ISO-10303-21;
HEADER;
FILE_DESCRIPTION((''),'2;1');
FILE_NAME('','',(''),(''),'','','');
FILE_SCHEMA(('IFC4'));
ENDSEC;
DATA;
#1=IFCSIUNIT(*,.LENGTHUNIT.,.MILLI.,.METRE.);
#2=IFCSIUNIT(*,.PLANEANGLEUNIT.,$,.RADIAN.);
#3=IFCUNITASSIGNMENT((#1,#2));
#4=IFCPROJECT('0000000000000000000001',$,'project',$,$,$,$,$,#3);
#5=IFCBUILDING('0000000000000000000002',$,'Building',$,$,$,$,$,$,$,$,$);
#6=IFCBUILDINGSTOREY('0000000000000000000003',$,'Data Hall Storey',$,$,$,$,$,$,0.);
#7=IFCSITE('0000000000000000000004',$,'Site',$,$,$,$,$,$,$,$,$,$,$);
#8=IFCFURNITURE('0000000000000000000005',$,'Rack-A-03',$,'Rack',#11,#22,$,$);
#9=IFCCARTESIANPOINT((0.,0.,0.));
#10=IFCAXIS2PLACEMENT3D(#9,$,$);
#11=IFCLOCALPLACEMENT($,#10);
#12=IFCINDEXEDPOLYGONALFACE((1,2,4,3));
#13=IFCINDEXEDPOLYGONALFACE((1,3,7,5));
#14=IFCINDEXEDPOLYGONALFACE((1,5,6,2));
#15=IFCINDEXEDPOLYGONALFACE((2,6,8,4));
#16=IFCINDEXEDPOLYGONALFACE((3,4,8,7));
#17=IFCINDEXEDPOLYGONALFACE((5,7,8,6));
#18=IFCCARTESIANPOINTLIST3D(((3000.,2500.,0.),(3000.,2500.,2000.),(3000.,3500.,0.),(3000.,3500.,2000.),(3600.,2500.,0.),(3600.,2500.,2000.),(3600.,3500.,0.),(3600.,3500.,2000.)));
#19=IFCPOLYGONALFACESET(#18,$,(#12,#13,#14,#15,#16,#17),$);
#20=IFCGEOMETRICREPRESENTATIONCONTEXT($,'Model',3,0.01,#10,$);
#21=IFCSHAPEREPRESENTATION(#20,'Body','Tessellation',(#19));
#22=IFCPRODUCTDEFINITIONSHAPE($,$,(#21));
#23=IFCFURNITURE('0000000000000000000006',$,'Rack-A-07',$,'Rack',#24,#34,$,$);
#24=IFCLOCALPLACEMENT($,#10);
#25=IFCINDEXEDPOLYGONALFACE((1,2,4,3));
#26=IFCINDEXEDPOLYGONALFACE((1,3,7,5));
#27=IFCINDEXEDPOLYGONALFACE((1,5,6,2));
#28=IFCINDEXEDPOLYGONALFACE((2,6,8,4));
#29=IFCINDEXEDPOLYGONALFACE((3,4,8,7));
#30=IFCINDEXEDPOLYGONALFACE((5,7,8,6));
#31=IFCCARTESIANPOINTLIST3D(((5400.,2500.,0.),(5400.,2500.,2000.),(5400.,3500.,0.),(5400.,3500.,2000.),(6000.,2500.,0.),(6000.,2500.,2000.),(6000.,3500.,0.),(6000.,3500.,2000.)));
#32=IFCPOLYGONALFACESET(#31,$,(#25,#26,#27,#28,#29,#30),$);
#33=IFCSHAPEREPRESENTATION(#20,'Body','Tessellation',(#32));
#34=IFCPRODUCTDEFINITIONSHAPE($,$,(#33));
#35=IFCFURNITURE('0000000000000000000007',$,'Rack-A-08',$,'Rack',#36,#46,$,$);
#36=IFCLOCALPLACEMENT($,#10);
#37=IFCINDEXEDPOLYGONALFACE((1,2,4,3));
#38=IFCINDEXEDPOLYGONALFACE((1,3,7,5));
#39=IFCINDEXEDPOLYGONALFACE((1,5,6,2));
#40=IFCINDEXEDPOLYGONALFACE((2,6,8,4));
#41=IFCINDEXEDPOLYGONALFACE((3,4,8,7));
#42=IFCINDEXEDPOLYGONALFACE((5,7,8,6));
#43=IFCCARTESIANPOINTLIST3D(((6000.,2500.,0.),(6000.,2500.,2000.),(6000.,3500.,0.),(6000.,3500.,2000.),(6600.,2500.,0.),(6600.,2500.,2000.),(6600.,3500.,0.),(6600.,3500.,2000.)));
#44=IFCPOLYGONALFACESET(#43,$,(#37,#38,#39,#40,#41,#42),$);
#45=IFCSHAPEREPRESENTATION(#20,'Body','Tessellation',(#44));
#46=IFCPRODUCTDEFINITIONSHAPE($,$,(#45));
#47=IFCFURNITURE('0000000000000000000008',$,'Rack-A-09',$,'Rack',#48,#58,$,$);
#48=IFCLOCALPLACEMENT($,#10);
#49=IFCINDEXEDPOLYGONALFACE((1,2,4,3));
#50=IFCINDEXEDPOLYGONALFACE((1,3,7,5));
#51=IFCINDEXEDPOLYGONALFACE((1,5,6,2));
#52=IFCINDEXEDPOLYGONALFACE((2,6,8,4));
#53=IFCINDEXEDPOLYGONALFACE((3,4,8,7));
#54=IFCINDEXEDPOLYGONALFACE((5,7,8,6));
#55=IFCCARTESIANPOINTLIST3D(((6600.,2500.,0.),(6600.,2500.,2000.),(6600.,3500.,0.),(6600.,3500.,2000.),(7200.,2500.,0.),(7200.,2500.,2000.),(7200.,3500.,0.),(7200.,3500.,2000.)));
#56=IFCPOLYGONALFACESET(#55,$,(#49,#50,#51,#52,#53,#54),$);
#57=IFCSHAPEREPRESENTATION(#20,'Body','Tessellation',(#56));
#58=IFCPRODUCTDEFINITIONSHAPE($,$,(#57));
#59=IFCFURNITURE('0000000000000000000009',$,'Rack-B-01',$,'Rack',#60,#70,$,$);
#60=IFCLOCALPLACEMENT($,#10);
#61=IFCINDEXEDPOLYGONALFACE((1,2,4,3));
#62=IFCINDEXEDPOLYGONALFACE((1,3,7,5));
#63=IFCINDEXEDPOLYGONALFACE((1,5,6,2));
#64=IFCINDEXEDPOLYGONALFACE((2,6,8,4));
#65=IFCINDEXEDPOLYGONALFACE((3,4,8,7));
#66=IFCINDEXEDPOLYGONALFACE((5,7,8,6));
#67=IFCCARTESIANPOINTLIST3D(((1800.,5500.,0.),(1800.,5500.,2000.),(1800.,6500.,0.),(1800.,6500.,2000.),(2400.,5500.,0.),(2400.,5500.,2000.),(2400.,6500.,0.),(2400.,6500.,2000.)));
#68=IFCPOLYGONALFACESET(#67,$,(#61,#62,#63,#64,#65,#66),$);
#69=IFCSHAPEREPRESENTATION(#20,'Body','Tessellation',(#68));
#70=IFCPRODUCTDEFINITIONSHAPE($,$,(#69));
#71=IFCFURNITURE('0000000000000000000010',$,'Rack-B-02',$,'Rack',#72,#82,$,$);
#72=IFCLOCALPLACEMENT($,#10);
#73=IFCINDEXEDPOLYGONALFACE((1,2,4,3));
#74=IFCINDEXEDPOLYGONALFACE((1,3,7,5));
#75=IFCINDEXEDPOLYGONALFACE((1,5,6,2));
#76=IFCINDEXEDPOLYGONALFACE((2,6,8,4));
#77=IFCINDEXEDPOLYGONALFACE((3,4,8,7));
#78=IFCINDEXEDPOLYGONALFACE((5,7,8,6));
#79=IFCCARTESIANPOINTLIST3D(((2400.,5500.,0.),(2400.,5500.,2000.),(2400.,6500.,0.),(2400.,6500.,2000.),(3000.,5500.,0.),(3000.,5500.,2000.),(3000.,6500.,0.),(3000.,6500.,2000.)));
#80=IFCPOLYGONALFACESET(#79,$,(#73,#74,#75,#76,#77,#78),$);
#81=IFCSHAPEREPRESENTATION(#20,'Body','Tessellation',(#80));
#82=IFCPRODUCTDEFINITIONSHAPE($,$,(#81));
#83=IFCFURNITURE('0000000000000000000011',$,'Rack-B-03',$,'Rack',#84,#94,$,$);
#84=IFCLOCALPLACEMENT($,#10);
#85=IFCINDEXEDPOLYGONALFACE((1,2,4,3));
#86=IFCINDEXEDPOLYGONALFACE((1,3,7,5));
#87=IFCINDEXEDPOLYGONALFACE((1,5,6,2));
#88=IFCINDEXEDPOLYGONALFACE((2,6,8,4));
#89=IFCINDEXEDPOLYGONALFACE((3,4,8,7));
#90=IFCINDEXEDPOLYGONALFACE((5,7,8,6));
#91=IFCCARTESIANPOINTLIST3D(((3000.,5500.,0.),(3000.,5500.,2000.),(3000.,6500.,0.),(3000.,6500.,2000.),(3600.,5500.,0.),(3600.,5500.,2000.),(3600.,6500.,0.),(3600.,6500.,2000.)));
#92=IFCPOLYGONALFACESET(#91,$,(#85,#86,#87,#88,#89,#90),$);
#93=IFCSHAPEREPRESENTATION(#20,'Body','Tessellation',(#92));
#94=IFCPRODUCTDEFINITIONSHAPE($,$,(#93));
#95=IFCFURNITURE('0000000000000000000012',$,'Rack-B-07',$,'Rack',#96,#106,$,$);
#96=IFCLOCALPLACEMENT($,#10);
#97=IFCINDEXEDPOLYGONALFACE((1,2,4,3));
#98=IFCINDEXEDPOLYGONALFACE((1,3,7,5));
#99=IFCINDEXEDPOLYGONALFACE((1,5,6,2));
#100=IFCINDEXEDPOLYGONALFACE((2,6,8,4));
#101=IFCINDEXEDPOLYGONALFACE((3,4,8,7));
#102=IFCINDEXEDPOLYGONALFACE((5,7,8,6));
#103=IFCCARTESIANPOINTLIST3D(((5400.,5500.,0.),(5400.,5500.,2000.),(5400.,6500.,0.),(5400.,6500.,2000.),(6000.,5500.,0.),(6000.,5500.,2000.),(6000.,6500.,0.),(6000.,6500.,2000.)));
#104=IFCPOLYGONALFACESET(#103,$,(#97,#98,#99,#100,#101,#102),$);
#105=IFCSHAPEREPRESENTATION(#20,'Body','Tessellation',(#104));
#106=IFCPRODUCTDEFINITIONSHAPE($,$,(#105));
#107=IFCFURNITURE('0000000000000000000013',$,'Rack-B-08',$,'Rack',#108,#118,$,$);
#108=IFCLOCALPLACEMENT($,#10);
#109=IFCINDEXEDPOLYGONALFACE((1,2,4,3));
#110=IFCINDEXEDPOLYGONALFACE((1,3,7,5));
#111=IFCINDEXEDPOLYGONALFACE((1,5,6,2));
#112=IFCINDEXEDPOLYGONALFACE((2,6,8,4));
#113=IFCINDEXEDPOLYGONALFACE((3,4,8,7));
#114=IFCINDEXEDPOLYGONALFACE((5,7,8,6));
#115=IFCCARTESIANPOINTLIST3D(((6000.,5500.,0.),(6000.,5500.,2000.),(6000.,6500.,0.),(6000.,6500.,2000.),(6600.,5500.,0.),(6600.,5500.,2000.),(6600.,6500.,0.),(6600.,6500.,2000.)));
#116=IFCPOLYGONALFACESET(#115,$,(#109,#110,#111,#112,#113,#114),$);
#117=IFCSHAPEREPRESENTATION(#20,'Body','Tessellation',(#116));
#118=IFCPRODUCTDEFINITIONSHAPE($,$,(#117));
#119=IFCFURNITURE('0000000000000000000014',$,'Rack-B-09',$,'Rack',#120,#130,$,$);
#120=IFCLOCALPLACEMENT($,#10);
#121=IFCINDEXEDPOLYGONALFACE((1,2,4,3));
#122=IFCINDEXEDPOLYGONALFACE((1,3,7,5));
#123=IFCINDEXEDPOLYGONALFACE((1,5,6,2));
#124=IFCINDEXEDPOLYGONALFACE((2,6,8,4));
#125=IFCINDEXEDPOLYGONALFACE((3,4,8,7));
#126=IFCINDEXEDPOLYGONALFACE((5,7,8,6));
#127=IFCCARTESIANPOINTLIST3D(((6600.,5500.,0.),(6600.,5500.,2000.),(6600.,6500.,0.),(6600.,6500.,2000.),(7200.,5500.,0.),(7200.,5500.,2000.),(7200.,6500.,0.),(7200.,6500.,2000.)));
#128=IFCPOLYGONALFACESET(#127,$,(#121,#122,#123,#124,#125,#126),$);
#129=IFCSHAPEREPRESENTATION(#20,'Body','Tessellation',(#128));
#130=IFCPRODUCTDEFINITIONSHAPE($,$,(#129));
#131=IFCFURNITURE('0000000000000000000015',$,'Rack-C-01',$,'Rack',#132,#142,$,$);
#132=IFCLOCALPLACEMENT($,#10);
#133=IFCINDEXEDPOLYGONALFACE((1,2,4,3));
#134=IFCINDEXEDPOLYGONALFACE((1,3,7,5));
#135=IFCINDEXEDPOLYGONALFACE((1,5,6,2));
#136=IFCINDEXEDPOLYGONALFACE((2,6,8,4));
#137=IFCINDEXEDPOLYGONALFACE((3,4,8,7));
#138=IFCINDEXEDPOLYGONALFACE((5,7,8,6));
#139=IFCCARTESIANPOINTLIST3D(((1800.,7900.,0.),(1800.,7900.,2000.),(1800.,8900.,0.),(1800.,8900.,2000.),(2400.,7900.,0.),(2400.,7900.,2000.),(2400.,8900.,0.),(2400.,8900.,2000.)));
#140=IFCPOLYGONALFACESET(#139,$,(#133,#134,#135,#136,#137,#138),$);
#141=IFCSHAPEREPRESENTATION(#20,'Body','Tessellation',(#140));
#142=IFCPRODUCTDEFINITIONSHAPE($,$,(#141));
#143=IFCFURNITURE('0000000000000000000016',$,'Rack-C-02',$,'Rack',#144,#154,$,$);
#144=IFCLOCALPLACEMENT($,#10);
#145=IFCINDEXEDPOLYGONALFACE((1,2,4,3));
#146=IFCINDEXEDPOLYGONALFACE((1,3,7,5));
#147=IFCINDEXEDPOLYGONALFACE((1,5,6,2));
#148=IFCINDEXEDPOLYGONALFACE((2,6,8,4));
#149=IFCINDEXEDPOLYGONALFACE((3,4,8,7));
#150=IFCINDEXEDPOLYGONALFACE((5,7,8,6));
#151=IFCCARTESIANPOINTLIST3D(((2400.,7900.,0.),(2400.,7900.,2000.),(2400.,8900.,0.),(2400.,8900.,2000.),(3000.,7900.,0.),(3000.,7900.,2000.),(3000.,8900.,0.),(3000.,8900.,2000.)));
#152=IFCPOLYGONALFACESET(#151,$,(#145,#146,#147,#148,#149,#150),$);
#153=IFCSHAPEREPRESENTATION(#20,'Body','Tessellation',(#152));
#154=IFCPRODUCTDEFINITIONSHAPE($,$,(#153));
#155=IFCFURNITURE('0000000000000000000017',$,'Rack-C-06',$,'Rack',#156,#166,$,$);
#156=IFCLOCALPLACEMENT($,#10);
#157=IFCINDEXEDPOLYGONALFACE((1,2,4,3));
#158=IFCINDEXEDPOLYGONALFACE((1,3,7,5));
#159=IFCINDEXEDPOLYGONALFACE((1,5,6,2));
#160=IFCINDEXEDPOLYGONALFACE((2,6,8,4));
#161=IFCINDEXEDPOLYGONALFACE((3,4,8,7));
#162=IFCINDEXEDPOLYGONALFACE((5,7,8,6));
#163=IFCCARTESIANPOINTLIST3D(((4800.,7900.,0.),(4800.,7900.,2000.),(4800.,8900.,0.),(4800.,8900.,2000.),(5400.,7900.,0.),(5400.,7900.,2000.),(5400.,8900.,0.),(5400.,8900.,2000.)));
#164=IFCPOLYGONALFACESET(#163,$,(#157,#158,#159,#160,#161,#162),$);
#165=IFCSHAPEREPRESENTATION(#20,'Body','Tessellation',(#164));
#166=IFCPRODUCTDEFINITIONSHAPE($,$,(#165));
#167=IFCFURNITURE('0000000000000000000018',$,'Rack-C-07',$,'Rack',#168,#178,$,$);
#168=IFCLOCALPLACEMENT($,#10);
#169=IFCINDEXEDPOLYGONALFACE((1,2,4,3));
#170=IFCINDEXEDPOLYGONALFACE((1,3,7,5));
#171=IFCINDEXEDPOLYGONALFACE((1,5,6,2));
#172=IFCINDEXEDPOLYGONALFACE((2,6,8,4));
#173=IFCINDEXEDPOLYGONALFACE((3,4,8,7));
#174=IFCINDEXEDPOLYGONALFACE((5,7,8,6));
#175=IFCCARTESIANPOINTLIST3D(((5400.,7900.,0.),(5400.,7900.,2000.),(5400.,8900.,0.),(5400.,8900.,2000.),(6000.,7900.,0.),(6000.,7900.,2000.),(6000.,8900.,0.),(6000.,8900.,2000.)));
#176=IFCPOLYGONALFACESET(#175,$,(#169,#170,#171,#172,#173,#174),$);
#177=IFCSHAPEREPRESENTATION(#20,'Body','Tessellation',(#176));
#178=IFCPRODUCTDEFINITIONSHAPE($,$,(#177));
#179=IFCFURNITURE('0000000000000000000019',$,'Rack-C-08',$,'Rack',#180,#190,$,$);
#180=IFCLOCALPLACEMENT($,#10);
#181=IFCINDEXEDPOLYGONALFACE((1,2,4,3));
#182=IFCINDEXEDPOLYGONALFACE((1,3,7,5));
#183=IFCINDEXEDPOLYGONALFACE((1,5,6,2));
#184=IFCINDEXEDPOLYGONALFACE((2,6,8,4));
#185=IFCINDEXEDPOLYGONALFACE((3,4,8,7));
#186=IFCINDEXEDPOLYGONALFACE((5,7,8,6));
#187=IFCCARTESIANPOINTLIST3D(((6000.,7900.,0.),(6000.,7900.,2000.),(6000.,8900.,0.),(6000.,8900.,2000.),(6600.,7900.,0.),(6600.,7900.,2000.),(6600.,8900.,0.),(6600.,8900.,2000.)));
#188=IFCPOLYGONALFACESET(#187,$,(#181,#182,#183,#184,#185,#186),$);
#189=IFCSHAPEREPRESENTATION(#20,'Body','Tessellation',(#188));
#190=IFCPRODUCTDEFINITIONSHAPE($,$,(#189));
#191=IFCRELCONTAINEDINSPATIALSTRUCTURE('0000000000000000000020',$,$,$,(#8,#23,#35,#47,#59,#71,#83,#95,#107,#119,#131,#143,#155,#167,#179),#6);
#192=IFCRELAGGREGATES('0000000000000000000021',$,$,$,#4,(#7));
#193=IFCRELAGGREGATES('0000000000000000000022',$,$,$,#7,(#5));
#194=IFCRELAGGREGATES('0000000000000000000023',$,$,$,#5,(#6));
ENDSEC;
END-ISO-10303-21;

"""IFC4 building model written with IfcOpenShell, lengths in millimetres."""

from ifc_helpers import new_model, si_unit, frame, origin, place, context, project, spatial, rectangle, extrude, element, save


model = new_model("IFC4")

# Units and contexts
model_context = context("Model", 3, precision=0.01, world=origin())
ifc_project = project(units=[si_unit("LENGTHUNIT", "METRE", prefix="MILLI"), si_unit("PLANEANGLEUNIT", "RADIAN")])

# Site, building, storey
site = spatial("IfcSite", under=ifc_project, Name="Site")
building = spatial("IfcBuilding", under=site, Name="Building")
storey = spatial("IfcBuildingStorey", under=building, Name="Data Hall Storey", Elevation=0.0)

# Furniture
for number, where, name in (
    (1, (3300.0, 3000.0, 0.0), "Rack-A-03"),
    (2, (5700.0, 3000.0, 0.0), "Rack-A-07"),
    (3, (6300.0, 3000.0, 0.0), "Rack-A-08"),
    (4, (6900.0, 3000.0, 0.0), "Rack-A-09"),
    (5, (2100.0, 6000.0, 0.0), "Rack-B-01"),
    (6, (2700.0, 6000.0, 0.0), "Rack-B-02"),
    (7, (3300.0, 6000.0, 0.0), "Rack-B-03"),
    (8, (5700.0, 6000.0, 0.0), "Rack-B-07"),
    (9, (6300.0, 6000.0, 0.0), "Rack-B-08"),
    (10, (6900.0, 6000.0, 0.0), "Rack-B-09"),
    (11, (2100.0, 8400.0, 0.0), "Rack-C-01"),
    (12, (2700.0, 8400.0, 0.0), "Rack-C-02"),
    (13, (5100.0, 8400.0, 0.0), "Rack-C-06"),
    (14, (5700.0, 8400.0, 0.0), "Rack-C-07"),
    (15, (6300.0, 8400.0, 0.0), "Rack-C-08"),
):
    element("IfcFurniture", number, at=place(None, frame(where)), inside=storey, Name=name, ObjectType="Rack", context=model_context, shape_type="SweptSolid", body=[
        extrude(rectangle(XDim=600.0, YDim=1000.0), origin(), (0.0, 0.0, 1.0), 2000.0),
    ])

save(model, "model.ifc")
